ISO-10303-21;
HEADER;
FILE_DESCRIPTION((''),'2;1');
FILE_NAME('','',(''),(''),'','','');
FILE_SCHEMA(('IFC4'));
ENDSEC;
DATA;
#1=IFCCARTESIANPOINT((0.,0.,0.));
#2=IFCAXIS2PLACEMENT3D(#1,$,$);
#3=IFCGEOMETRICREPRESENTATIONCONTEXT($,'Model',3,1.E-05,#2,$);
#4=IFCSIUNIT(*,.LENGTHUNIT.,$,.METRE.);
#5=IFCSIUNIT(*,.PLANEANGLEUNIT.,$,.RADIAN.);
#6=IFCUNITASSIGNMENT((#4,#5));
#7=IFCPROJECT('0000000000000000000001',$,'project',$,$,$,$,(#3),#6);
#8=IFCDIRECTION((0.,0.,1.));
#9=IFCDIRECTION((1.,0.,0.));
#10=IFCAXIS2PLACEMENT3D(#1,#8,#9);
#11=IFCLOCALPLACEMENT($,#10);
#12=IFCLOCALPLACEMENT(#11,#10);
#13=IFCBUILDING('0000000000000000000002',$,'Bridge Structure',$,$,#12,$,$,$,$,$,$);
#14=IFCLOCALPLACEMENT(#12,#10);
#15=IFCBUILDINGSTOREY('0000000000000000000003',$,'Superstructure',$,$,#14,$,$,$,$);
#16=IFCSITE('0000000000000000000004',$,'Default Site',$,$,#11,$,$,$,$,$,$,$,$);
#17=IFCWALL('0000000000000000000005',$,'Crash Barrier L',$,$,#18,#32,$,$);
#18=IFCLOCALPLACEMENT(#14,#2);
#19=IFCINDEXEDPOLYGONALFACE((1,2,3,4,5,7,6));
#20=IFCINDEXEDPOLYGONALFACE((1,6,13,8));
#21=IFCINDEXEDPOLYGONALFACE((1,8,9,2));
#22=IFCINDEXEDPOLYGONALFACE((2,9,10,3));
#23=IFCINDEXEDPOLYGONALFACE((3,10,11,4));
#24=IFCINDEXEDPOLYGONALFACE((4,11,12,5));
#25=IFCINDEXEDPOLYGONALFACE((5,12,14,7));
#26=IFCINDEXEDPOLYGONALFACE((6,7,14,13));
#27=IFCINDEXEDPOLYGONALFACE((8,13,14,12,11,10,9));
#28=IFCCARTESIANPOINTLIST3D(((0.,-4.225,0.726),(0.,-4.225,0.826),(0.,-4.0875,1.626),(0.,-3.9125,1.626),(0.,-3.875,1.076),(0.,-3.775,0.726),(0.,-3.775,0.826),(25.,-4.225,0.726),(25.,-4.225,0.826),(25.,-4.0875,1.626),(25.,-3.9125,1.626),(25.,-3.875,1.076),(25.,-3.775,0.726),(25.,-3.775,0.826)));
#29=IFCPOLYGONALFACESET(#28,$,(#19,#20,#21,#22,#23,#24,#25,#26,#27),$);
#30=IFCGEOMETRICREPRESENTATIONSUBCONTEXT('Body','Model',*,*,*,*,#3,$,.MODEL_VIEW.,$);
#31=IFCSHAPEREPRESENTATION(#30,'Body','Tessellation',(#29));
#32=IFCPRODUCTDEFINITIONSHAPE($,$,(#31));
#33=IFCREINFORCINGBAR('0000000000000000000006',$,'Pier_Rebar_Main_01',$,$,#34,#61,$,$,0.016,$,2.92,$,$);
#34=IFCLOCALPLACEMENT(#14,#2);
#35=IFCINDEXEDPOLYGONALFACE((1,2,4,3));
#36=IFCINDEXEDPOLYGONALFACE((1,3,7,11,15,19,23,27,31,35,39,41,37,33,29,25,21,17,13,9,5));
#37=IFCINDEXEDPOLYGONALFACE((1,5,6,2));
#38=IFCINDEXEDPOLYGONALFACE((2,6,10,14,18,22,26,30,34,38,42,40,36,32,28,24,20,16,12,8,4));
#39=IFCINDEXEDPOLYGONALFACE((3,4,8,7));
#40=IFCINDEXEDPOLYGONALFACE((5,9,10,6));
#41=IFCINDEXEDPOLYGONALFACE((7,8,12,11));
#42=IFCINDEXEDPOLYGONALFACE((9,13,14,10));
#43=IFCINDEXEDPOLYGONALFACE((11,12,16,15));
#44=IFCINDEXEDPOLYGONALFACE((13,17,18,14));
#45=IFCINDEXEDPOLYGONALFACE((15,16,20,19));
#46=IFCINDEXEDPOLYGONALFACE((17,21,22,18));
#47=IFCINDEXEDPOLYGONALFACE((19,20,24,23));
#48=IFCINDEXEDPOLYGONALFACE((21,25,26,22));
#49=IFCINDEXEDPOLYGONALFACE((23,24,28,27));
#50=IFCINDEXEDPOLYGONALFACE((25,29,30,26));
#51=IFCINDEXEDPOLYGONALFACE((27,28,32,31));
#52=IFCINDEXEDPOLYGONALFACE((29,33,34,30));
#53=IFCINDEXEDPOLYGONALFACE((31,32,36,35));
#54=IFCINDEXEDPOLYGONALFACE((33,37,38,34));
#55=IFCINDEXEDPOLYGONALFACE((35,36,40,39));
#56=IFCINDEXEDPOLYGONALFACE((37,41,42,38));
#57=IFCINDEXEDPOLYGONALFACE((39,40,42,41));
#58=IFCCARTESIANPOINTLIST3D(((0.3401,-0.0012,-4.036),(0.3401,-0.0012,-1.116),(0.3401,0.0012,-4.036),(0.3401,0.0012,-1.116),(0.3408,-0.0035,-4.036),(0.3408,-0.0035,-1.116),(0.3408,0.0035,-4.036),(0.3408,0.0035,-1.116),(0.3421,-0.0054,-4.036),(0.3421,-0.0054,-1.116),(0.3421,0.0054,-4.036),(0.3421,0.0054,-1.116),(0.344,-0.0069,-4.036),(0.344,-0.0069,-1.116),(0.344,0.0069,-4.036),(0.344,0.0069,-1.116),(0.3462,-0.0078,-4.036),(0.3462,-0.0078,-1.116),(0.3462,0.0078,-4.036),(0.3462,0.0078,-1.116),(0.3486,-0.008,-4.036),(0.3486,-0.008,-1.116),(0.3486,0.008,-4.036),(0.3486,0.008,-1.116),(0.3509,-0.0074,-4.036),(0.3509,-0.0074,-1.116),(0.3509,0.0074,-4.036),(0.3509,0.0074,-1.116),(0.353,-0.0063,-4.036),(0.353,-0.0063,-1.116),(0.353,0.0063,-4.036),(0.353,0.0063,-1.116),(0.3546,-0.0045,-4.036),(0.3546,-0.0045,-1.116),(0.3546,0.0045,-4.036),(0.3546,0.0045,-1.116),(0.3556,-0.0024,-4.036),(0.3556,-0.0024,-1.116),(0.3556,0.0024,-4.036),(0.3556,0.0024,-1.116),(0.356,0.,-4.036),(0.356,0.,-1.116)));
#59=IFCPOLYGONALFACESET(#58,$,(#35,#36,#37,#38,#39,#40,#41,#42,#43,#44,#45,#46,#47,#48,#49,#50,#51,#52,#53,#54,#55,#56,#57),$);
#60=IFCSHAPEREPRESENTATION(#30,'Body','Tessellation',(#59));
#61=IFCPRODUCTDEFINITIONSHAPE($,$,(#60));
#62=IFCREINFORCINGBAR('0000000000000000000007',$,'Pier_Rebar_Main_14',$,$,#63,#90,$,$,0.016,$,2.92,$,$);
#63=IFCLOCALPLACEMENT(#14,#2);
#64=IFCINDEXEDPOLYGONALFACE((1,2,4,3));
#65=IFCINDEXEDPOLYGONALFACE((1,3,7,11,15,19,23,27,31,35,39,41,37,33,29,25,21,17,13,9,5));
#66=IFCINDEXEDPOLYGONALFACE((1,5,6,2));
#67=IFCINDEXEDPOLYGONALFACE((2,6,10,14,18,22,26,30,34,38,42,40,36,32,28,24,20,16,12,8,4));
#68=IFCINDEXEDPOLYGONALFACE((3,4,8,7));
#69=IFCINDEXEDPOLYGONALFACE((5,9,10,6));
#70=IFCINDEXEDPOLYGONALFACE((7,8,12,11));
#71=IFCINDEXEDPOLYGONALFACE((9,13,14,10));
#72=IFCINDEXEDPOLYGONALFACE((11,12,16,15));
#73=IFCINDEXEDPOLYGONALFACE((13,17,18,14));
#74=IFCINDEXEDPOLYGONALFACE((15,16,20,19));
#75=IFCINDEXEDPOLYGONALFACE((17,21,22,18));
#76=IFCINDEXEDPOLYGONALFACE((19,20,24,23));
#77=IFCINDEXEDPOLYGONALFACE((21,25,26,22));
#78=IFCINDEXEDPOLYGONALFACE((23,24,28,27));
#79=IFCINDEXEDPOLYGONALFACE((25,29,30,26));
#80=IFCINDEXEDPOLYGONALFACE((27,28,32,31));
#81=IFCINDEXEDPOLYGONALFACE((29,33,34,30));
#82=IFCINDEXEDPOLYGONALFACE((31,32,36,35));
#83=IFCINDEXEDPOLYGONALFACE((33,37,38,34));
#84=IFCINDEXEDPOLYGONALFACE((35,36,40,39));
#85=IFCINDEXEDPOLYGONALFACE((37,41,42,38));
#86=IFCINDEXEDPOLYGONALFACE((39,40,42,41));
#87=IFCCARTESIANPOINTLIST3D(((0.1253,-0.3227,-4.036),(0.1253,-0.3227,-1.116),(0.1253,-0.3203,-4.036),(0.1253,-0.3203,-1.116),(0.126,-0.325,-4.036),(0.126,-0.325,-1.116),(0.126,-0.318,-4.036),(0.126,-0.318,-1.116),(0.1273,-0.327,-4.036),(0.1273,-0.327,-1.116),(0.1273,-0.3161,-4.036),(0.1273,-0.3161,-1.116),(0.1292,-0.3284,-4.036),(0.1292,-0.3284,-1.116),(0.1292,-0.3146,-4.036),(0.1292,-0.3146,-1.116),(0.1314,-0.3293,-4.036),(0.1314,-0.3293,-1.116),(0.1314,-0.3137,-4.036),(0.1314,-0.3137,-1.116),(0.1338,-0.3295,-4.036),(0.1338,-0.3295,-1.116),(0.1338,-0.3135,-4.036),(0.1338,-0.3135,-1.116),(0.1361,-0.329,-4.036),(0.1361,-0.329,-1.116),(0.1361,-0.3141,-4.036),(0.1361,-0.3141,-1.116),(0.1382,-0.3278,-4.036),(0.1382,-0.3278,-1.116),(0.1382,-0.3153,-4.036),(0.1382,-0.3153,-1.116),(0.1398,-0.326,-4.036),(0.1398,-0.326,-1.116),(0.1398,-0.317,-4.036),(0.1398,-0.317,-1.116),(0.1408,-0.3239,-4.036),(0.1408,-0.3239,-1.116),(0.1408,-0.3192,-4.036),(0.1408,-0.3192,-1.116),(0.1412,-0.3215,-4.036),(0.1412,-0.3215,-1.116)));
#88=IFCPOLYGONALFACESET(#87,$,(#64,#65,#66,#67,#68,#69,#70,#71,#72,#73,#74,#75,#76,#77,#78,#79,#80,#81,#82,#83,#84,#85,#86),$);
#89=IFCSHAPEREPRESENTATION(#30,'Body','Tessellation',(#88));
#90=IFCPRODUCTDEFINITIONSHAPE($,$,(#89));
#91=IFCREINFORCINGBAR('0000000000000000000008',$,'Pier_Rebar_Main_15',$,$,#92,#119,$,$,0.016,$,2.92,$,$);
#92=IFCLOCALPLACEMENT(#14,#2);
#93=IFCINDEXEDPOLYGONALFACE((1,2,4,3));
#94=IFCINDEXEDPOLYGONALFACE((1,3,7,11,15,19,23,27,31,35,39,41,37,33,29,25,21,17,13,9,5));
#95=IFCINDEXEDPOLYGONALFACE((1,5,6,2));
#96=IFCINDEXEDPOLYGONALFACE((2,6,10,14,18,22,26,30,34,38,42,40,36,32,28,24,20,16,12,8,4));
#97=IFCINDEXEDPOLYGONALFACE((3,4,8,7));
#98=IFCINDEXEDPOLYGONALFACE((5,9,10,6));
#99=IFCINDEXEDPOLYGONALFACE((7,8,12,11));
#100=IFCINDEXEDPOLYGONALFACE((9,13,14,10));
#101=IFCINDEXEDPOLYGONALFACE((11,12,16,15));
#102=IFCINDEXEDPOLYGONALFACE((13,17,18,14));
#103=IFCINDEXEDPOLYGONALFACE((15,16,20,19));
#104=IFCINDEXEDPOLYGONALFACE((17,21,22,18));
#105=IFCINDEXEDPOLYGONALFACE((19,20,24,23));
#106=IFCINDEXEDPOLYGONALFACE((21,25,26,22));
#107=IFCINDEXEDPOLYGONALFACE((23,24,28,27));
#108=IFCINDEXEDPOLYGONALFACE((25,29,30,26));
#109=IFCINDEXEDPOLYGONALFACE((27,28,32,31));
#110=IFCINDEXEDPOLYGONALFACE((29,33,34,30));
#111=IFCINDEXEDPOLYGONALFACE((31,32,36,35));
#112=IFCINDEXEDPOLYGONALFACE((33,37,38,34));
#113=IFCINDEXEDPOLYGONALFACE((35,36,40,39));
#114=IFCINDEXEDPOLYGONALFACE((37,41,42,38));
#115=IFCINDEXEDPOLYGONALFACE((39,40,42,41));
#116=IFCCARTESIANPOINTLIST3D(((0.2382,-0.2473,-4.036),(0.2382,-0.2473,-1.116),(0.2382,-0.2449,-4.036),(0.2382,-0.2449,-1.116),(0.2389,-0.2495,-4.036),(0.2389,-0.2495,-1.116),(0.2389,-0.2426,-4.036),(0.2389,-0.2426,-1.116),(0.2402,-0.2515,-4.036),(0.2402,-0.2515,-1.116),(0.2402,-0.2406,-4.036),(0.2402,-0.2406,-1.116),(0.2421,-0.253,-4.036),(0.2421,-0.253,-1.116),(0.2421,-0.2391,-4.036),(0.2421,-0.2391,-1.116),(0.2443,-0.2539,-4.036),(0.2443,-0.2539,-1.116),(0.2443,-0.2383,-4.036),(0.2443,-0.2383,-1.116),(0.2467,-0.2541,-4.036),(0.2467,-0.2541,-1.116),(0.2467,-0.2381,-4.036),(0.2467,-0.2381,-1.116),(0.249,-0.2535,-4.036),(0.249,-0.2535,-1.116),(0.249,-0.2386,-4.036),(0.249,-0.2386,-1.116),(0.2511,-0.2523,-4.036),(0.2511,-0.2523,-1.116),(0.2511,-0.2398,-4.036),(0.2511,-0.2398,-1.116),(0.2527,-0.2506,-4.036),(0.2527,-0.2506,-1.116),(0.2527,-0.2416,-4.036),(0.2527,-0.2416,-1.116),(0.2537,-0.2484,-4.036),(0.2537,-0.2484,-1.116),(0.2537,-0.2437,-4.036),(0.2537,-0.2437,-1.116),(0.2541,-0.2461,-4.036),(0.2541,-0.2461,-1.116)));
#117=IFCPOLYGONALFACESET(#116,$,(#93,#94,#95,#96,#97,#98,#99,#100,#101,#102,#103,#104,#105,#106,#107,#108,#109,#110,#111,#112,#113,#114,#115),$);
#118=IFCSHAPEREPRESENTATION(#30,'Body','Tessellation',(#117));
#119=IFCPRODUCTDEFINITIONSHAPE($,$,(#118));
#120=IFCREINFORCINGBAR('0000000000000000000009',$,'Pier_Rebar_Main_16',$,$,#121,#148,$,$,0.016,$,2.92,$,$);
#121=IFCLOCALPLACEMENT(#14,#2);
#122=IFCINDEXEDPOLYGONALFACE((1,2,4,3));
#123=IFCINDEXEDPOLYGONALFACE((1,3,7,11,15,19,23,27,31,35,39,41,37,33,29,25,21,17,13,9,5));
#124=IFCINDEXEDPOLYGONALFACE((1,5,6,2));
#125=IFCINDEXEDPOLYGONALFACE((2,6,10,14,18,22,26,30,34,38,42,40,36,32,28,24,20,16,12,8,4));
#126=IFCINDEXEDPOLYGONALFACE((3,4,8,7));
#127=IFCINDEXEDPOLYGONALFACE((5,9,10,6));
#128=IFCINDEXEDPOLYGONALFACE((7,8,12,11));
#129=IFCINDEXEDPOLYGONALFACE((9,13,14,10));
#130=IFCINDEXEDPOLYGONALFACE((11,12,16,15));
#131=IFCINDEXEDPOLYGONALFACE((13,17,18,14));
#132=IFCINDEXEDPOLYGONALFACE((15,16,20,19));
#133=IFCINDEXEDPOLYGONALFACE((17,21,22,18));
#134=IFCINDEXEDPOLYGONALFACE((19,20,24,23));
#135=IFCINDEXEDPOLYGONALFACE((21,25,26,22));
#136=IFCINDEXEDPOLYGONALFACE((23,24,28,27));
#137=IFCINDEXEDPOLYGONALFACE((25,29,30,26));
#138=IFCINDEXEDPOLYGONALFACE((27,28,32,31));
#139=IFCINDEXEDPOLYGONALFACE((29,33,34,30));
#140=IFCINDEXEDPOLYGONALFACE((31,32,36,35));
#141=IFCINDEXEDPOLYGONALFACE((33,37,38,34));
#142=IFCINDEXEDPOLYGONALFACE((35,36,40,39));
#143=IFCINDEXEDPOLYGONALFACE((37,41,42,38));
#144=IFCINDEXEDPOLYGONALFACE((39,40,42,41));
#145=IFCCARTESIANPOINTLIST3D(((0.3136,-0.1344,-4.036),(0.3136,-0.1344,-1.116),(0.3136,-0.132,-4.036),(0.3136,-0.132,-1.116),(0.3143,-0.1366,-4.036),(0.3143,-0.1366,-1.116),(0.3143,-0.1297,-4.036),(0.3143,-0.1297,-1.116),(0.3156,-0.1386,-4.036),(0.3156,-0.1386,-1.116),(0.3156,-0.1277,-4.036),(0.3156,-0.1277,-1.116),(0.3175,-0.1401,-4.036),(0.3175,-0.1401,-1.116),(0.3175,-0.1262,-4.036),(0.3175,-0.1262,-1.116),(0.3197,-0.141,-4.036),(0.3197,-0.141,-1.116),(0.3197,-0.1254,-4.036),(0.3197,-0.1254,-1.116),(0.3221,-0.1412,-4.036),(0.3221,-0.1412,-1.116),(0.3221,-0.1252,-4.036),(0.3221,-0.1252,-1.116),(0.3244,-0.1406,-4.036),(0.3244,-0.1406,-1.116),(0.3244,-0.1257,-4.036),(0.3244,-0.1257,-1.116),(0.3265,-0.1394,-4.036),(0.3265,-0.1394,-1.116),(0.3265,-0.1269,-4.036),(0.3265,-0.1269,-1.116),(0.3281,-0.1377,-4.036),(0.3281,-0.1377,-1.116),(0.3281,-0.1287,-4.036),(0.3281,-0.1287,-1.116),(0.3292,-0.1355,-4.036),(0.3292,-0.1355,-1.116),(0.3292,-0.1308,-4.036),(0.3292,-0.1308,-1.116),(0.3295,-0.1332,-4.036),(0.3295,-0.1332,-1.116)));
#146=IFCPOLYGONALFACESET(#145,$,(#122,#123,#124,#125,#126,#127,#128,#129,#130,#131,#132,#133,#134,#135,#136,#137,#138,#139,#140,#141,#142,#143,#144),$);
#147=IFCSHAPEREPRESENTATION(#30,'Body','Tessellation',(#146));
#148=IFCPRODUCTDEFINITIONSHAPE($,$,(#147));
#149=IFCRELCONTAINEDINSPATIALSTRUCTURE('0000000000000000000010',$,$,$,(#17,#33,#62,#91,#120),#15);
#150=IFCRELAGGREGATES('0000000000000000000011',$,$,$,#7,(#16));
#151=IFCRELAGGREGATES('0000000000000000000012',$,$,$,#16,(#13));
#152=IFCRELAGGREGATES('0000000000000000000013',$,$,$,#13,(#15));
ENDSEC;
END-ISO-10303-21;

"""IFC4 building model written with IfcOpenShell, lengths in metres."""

from ifc_helpers import new_model, si_unit, frame, origin, origin_with_axes, origin_2d_with_axis, place, context, subcontext, project, spatial, polyline, circle, outline, extrude, element, save


model = new_model("IFC4")

# Units and contexts
model_context = context("Model", 3, precision=1e-05, world=origin())
body_context = subcontext(model_context, "Body", "Model", "MODEL_VIEW")
ifc_project = project(units=[si_unit("LENGTHUNIT", "METRE"), si_unit("PLANEANGLEUNIT", "RADIAN")], contexts=[model_context])

# Site, building, storey
site_placement = place(None, origin_with_axes())
site = spatial("IfcSite", under=ifc_project, at=site_placement, Name="Default Site")
building_placement = place(site_placement, origin_with_axes())
building = spatial("IfcBuilding", under=site, at=building_placement, Name="Bridge Structure")
storey_placement = place(building_placement, origin_with_axes())
storey = spatial("IfcBuildingStorey", under=building, at=storey_placement, Name="Superstructure")

# Wall
wall_placement = place(storey_placement, frame((0.0, -4.225, 0.726), z_axis=(1.0, 0.0, 0.0), x_axis=(0.0, 1.0, 0.0)))
element("IfcWall", 1, at=wall_placement, inside=storey, Name="Crash Barrier L", context=body_context, shape_type="SweptSolid", body=[
    extrude(outline(polyline([(0.0, 0.0), (0.45, 0.0), (0.45, 0.1), (0.35, 0.35), (0.3125, 0.9), (0.1375, 0.9), (0.0, 0.1), (0.0, 0.0)])), origin_with_axes(), (0.0, 0.0, 1.0), 25.0),
])

# Reinforcing bars
for number, where, z_axis, x_axis, name in (
    (2, (0.348, 0.0, -4.036), (0.0, 0.0, 1.0), (1.0, 0.0, 0.0), "Pier_Rebar_Main_01"),
    (3, (0.1332, -0.3215, -4.036), (0.0, 0.0, 1.0), (1.0, 0.0, 0.0), "Pier_Rebar_Main_14"),
    (4, (0.2461, -0.2461, -4.036), (0.0, 0.0, 1.0), (1.0, 0.0, 0.0), "Pier_Rebar_Main_15"),
    (5, (0.3215, -0.1332, -4.036), (0.0, 0.0, 1.0), (1.0, 0.0, 0.0), "Pier_Rebar_Main_16"),
):
    element("IfcReinforcingBar", number, at=place(storey_placement, frame(where, z_axis=z_axis, x_axis=x_axis)), inside=storey, Name=name, BarLength=2.92, NominalDiameter=0.016, context=body_context, shape_type="SweptSolid", body=[
        extrude(circle(Radius=0.008, at=origin_2d_with_axis()), origin_with_axes(), (0.0, 0.0, 1.0), 2.92),
    ])

save(model, "model.ifc")
